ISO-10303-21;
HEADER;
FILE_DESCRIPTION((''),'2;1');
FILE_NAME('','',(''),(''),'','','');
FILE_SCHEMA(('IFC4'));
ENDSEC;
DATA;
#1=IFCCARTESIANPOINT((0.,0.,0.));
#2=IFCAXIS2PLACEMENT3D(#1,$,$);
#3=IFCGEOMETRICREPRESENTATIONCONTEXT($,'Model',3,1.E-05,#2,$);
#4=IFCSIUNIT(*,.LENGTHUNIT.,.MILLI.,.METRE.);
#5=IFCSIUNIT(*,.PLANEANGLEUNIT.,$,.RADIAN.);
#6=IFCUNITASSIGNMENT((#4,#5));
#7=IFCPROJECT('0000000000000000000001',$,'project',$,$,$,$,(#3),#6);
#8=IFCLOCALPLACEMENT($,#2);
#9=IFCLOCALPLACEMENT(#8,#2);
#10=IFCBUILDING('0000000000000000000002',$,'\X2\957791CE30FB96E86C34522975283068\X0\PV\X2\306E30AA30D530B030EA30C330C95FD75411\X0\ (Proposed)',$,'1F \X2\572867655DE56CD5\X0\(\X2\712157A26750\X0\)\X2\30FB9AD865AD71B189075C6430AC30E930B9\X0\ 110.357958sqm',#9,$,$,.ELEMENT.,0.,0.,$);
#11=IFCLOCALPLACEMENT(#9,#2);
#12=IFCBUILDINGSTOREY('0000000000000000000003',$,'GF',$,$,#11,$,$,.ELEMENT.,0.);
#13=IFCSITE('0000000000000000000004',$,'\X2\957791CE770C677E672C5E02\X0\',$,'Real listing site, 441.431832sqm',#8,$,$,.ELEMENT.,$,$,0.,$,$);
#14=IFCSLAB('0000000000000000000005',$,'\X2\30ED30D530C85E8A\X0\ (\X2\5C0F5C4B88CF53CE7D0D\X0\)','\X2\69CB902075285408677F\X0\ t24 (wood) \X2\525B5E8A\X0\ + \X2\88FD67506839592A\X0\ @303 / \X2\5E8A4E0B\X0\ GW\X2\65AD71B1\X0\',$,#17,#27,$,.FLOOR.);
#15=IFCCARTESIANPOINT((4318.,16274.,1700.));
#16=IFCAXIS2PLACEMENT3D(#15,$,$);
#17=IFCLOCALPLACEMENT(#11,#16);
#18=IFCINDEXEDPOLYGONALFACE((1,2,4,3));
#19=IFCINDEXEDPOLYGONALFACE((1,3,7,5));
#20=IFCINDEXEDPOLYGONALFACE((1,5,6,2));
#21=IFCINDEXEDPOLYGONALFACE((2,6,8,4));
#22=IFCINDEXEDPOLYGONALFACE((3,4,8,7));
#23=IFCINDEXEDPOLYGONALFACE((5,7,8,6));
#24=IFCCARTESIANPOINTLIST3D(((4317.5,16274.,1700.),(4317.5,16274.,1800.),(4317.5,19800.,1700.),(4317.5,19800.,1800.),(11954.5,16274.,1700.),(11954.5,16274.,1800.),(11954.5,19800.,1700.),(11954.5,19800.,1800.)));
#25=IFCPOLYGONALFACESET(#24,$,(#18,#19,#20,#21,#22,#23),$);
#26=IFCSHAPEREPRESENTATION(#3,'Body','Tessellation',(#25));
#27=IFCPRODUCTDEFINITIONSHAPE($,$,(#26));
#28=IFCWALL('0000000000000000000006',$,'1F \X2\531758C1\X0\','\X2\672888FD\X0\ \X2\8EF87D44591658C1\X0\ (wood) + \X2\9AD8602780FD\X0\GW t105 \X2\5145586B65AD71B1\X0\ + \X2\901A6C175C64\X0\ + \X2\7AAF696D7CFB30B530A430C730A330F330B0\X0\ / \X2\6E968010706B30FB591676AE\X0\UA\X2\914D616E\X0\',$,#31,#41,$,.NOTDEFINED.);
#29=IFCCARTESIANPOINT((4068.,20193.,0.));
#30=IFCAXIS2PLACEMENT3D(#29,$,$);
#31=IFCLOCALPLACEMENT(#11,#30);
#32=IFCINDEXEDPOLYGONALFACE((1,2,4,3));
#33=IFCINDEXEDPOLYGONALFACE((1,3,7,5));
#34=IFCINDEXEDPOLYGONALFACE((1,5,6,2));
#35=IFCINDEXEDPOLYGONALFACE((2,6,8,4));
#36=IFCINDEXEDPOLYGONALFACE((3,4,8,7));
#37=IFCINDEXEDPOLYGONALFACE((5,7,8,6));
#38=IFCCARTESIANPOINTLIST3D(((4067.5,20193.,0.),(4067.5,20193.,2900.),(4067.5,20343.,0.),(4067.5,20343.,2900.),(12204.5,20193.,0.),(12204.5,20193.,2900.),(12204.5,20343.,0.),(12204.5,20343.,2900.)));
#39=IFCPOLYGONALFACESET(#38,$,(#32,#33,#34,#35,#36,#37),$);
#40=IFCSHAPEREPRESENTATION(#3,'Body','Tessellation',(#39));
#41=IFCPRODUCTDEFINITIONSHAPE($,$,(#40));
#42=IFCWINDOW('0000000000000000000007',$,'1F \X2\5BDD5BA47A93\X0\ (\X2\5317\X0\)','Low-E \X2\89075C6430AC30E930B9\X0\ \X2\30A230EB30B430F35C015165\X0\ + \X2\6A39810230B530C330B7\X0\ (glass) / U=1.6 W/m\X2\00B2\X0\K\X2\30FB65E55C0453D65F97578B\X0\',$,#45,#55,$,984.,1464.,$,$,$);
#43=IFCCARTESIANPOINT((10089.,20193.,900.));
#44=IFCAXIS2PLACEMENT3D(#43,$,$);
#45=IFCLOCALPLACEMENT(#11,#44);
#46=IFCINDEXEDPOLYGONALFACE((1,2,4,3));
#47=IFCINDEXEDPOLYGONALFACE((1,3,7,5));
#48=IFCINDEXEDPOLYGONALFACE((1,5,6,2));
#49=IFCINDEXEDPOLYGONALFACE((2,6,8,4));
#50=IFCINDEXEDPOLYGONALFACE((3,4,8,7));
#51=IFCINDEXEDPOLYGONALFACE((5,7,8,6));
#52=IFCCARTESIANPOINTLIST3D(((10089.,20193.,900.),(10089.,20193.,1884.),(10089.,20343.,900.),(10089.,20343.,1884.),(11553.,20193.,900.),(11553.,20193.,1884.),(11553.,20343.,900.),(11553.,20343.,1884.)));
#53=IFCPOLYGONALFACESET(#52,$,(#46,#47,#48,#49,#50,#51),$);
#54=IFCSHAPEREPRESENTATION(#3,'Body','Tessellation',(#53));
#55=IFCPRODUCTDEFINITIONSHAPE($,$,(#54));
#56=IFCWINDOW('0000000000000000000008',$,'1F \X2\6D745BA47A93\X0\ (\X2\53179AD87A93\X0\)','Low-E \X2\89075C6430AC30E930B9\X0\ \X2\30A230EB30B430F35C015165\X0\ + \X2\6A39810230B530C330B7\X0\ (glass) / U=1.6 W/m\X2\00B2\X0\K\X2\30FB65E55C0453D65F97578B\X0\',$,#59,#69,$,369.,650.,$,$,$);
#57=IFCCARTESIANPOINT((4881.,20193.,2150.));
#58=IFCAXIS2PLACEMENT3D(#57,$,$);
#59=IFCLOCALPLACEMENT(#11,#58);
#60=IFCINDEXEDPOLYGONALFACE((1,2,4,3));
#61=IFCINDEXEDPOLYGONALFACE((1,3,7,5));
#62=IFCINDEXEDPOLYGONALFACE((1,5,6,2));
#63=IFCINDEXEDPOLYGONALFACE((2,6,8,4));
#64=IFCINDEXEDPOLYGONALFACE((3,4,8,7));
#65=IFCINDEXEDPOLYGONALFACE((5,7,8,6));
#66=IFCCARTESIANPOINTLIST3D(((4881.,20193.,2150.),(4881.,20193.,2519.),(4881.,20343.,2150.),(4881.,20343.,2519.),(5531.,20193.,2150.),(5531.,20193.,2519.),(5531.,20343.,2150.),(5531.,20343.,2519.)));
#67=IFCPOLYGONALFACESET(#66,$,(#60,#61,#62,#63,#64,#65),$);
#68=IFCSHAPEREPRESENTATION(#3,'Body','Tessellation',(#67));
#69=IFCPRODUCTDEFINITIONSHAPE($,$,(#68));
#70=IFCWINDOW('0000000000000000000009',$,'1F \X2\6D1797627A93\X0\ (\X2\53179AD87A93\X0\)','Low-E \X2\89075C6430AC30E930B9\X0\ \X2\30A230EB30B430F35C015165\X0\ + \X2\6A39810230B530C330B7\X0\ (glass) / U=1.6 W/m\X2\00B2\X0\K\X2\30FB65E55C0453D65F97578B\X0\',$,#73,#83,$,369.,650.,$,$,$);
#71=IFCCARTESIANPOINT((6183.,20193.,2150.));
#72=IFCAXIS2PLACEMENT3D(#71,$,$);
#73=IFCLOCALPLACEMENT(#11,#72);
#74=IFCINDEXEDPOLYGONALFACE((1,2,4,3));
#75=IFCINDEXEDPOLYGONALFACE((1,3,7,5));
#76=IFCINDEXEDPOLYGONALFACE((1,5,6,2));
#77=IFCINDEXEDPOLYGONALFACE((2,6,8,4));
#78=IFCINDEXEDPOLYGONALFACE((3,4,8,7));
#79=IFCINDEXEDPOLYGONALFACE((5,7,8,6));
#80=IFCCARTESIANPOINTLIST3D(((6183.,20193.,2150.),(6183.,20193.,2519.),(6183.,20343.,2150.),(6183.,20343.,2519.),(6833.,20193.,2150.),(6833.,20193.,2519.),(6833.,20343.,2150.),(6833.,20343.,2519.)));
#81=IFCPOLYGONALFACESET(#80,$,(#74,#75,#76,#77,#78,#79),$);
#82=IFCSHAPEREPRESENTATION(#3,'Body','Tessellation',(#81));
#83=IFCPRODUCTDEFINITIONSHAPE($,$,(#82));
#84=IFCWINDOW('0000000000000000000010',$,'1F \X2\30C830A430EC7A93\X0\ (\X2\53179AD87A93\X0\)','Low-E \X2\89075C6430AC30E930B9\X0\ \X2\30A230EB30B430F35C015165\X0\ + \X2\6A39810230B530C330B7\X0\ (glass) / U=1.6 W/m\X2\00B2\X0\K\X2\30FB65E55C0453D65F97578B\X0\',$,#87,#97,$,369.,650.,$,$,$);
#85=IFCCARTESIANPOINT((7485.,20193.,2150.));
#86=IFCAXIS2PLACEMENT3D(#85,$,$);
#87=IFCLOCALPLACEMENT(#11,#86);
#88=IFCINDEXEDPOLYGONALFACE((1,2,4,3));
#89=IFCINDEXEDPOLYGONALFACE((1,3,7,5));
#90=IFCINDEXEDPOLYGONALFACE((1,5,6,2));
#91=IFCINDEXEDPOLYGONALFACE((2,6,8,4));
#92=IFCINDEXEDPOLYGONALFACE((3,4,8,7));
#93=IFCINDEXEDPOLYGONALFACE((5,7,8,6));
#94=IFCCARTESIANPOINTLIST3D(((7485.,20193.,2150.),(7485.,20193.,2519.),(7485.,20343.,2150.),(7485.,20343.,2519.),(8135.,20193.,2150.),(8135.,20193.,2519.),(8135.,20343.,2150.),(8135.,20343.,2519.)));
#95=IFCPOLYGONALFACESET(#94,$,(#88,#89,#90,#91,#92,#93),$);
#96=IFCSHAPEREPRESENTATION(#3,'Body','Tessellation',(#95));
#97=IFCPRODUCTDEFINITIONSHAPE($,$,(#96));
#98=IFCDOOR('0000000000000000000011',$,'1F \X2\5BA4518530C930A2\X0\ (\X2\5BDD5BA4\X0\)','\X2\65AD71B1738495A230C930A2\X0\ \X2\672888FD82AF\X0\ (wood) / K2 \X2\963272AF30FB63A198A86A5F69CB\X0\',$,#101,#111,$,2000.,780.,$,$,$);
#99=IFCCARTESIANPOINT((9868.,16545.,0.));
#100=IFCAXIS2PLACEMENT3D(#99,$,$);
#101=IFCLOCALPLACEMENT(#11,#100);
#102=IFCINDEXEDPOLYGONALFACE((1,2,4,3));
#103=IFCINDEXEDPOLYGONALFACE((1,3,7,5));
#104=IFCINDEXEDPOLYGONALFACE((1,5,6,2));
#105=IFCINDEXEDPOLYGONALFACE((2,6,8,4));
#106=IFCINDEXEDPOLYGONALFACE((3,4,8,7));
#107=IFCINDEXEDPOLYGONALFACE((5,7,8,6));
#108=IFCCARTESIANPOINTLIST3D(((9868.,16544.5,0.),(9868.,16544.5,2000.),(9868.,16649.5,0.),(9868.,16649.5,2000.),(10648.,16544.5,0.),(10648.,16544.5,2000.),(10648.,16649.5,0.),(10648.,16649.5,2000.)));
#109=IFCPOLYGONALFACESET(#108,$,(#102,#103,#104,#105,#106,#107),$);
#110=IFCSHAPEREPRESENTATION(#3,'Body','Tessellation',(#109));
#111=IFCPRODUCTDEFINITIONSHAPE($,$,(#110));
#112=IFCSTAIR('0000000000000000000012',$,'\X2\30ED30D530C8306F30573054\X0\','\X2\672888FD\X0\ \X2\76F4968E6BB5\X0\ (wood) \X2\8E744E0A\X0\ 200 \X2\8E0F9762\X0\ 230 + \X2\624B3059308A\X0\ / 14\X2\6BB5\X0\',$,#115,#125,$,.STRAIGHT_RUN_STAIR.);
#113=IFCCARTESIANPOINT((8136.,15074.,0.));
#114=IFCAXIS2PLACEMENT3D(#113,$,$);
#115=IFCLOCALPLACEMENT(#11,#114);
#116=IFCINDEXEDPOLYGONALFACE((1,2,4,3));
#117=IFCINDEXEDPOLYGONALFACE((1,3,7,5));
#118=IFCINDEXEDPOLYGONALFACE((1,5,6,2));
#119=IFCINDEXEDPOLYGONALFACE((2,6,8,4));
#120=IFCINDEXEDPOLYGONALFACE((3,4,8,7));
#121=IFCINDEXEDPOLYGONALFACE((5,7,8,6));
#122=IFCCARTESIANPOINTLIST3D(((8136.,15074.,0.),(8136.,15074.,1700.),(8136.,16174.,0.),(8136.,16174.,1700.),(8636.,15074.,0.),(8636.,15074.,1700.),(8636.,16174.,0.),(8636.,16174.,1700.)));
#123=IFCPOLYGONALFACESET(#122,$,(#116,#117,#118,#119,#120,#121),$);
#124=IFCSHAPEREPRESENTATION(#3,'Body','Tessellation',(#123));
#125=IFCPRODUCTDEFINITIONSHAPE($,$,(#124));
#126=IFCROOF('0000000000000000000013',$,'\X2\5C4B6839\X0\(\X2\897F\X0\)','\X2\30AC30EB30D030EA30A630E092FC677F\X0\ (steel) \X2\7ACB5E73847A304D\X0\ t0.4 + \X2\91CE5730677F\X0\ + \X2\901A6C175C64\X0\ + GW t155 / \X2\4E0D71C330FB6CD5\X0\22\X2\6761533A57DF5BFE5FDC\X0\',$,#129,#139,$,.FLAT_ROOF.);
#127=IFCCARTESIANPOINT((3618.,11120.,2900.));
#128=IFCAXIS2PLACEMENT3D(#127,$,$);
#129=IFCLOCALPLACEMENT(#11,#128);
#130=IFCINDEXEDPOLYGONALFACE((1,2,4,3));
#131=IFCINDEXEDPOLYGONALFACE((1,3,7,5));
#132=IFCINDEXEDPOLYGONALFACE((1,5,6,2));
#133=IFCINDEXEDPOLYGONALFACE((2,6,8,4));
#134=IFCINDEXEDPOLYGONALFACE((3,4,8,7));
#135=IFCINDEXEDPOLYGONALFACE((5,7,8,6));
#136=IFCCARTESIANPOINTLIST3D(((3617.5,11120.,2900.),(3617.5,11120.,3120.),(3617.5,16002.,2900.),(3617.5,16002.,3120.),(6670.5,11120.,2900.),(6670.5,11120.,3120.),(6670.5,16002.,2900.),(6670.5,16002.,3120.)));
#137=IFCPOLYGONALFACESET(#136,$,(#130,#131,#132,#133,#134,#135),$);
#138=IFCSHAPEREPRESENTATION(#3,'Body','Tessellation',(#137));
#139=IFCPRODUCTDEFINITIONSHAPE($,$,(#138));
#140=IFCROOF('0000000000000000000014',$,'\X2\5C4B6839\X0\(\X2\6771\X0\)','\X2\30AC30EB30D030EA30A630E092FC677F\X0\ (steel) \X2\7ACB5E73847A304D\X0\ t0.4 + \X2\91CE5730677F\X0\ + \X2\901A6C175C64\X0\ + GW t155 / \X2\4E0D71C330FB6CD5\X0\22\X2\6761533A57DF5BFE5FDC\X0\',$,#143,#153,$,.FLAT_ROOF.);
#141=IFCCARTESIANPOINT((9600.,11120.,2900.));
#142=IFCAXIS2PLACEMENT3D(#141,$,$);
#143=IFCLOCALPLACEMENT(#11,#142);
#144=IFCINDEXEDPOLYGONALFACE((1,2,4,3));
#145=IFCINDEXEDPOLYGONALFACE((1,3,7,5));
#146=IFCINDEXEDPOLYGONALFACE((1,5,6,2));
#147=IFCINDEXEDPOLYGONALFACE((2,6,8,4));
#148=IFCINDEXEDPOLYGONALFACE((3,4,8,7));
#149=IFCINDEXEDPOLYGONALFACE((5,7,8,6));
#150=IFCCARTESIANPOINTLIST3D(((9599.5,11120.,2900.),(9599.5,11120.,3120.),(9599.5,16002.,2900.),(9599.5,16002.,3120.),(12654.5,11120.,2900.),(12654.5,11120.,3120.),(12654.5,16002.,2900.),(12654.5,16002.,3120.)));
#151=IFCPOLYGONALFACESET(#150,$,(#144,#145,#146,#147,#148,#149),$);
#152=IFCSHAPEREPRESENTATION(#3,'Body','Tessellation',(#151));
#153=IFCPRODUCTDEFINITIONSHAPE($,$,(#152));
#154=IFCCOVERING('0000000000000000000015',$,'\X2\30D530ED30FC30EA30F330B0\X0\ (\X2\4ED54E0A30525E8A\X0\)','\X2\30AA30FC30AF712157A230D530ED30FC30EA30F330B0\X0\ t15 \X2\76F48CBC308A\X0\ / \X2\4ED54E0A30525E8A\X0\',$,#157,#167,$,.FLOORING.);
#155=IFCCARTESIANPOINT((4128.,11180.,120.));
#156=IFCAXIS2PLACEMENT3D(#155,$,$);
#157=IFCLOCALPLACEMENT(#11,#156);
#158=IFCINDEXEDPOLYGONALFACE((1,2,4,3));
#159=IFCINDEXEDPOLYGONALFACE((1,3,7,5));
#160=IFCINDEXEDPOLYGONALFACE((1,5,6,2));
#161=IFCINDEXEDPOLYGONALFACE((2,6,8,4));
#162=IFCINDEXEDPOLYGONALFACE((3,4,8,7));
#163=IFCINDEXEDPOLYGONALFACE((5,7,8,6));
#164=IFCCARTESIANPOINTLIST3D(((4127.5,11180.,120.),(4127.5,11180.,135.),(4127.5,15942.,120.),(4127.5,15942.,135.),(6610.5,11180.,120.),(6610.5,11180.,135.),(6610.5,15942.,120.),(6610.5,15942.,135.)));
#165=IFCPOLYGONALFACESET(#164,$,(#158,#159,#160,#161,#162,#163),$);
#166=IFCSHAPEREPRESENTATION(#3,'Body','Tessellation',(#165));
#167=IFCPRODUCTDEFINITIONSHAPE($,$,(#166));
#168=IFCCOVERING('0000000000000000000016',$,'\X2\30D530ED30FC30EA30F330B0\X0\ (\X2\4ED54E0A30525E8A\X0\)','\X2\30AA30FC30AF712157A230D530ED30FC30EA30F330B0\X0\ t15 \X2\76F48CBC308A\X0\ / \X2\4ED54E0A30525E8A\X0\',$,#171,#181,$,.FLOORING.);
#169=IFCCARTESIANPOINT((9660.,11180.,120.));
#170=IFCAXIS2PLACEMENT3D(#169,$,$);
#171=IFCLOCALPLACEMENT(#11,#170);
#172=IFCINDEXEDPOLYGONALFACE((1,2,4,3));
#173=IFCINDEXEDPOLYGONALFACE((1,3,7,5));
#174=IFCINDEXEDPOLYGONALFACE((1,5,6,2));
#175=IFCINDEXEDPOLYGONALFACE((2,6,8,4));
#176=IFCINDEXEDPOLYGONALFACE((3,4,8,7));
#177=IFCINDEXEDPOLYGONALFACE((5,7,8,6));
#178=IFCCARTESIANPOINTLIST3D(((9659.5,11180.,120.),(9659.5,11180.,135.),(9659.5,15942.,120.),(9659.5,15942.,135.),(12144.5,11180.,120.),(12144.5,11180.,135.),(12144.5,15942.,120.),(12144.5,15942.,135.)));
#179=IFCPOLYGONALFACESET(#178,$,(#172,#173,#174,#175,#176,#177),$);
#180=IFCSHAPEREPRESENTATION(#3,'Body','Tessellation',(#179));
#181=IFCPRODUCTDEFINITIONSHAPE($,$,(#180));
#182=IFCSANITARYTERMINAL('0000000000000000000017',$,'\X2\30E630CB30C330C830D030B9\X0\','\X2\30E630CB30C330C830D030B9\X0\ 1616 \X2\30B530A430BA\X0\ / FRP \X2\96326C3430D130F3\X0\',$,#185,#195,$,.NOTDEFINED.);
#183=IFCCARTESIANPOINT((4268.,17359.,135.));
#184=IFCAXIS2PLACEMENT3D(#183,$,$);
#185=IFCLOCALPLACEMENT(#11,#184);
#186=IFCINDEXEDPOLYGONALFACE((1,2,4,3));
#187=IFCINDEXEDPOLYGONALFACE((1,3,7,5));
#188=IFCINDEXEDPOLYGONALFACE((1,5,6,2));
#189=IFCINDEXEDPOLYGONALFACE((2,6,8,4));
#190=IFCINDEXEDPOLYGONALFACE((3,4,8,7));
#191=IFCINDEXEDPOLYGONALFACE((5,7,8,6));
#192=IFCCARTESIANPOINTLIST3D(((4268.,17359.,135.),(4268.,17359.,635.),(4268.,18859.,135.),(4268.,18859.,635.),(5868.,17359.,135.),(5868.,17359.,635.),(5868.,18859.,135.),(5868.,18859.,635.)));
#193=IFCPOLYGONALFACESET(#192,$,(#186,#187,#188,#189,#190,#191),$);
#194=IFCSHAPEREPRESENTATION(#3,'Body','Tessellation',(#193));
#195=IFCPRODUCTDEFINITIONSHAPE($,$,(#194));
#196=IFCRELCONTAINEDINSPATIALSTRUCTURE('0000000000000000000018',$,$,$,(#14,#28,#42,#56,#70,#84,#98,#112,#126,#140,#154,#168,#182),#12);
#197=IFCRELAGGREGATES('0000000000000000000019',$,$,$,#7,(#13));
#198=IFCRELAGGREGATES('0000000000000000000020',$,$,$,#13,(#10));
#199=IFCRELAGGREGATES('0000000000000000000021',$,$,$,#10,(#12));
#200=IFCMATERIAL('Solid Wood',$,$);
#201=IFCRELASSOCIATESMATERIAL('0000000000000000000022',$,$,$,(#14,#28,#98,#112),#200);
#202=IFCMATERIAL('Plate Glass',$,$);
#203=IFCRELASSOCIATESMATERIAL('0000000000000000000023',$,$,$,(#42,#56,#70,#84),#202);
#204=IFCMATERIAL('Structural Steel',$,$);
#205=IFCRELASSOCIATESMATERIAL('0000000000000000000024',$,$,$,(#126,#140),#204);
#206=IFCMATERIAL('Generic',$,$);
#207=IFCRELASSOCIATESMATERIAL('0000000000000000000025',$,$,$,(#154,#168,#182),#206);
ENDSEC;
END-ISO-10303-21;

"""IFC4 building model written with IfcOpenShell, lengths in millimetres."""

from ifc_helpers import new_model, si_unit, frame, frame_2d, origin, place, context, project, spatial, rectangle, extrude, material, element, fill, save


model = new_model("IFC4")

# Units and contexts
model_context = context("Model", 3, precision=1e-05, world=origin())
ifc_project = project(units=[si_unit("LENGTHUNIT", "METRE", prefix="MILLI"), si_unit("PLANEANGLEUNIT", "RADIAN")], contexts=[model_context])

# Site, building, storey
site_placement = place(None, origin())
site = spatial("IfcSite", under=ifc_project, at=site_placement, Name="長野県松本市", ObjectType="Real listing site, 441.431832sqm", CompositionType="ELEMENT", RefElevation=0.0)
building_placement = place(site_placement, origin())
building = spatial("IfcBuilding", under=site, at=building_placement, Name="長野・雨水利用とPVのオフグリッド志向 (Proposed)", ObjectType="1F 在来工法(無垢材)・高断熱複層ガラス 110.357958sqm", CompositionType="ELEMENT", ElevationOfRefHeight=0.0, ElevationOfTerrain=0.0)
storey_placement = place(building_placement, origin())
storey = spatial("IfcBuildingStorey", under=building, at=storey_placement, Name="GF", CompositionType="ELEMENT", Elevation=0.0)

# Slab
ifc_material_1 = material(Name="Solid Wood")
slab_1_placement = place(storey_placement, frame((4318.0, 16274.0, 1700.0)))
element("IfcSlab", 1, at=slab_1_placement, inside=storey, material=ifc_material_1, Name="ロフト床 (小屋裏収納)", Description="構造用合板 t24 (wood) 剛床 + 製材根太 @303 / 床下 GW断熱", PredefinedType="FLOOR", context=model_context, shape_type="SweptSolid", body=[
    extrude(rectangle(XDim=7637.0, YDim=3526.0, at=frame_2d((3818.0, 1763.0))), frame((4318.0, 16274.0, 1700.0)), (0.0, 0.0, 1.0), 100.0),
])

# Wall, openings, windows
wall_1_placement = place(storey_placement, frame((4068.0, 20193.0, 0.0)))
wall_1 = element("IfcWall", 2, at=wall_1_placement, inside=storey, material=ifc_material_1, Name="1F 北壁", Description="木製 軸組外壁 (wood) + 高性能GW t105 充填断熱 + 通気層 + 窯業系サイディング / 準耐火・外皮UA配慮", PredefinedType="NOTDEFINED", context=model_context, shape_type="SweptSolid", body=[
    extrude(rectangle(XDim=8137.0, YDim=150.0, at=frame_2d((4068.0, 75.0))), frame((4068.0, 20193.0, 0.0)), (0.0, 0.0, 1.0), 2900.0),
])
opening_1_placement = place(storey_placement, frame((10089.0, 20193.0, 900.0)))
opening_1 = element("IfcOpeningElement", 3, at=opening_1_placement, cuts=wall_1, PredefinedType="NOTDEFINED", context=model_context, shape_type="SweptSolid", body=[
    extrude(rectangle(XDim=1464.0, YDim=150.0, at=frame_2d((732.0, 75.0))), frame((10089.0, 20193.0, 900.0)), (0.0, 0.0, 1.0), 984.0),
])
opening_2_placement = place(storey_placement, frame((4881.0, 20193.0, 2150.0)))
opening_2 = element("IfcOpeningElement", 4, at=opening_2_placement, cuts=wall_1, PredefinedType="NOTDEFINED", context=model_context, shape_type="SweptSolid", body=[
    extrude(rectangle(XDim=650.0, YDim=150.0, at=frame_2d((325.0, 75.0))), frame((4881.0, 20193.0, 2150.0)), (0.0, 0.0, 1.0), 369.0),
])
opening_3_placement = place(storey_placement, frame((6183.0, 20193.0, 2150.0)))
opening_3 = element("IfcOpeningElement", 5, at=opening_3_placement, cuts=wall_1, PredefinedType="NOTDEFINED", context=model_context, shape_type="SweptSolid", body=[
    extrude(rectangle(XDim=650.0, YDim=150.0, at=frame_2d((325.0, 75.0))), frame((6183.0, 20193.0, 2150.0)), (0.0, 0.0, 1.0), 369.0),
])
opening_4_placement = place(storey_placement, frame((7485.0, 20193.0, 2150.0)))
opening_4 = element("IfcOpeningElement", 6, at=opening_4_placement, cuts=wall_1, PredefinedType="NOTDEFINED", context=model_context, shape_type="SweptSolid", body=[
    extrude(rectangle(XDim=650.0, YDim=150.0, at=frame_2d((325.0, 75.0))), frame((7485.0, 20193.0, 2150.0)), (0.0, 0.0, 1.0), 369.0),
])
ifc_material_2 = material(Name="Plate Glass")
window_1_placement = place(storey_placement, frame((10089.0, 20193.0, 900.0)))
window_1 = element("IfcWindow", 7, at=window_1_placement, inside=storey, material=ifc_material_2, Name="1F 寝室窓 (北)", Description="Low-E 複層ガラス アルゴン封入 + 樹脂サッシ (glass) / U=1.6 W/m²K・日射取得型", OverallHeight=984.0, OverallWidth=1464.0, context=model_context, shape_type="SweptSolid", body=[
    extrude(rectangle(XDim=1464.0, YDim=150.0, at=frame_2d((732.0, 75.0))), frame((10089.0, 20193.0, 900.0)), (0.0, 0.0, 1.0), 984.0),
])
fill(opening_1, window_1)
window_2_placement = place(storey_placement, frame((4881.0, 20193.0, 2150.0)))
window_2 = element("IfcWindow", 8, at=window_2_placement, inside=storey, material=ifc_material_2, Name="1F 浴室窓 (北高窓)", Description="Low-E 複層ガラス アルゴン封入 + 樹脂サッシ (glass) / U=1.6 W/m²K・日射取得型", OverallHeight=369.0, OverallWidth=650.0, context=model_context, shape_type="SweptSolid", body=[
    extrude(rectangle(XDim=650.0, YDim=150.0, at=frame_2d((325.0, 75.0))), frame((4881.0, 20193.0, 2150.0)), (0.0, 0.0, 1.0), 369.0),
])
fill(opening_2, window_2)
window_3_placement = place(storey_placement, frame((6183.0, 20193.0, 2150.0)))
window_3 = element("IfcWindow", 9, at=window_3_placement, inside=storey, material=ifc_material_2, Name="1F 洗面窓 (北高窓)", Description="Low-E 複層ガラス アルゴン封入 + 樹脂サッシ (glass) / U=1.6 W/m²K・日射取得型", OverallHeight=369.0, OverallWidth=650.0, context=model_context, shape_type="SweptSolid", body=[
    extrude(rectangle(XDim=650.0, YDim=150.0, at=frame_2d((325.0, 75.0))), frame((6183.0, 20193.0, 2150.0)), (0.0, 0.0, 1.0), 369.0),
])
fill(opening_3, window_3)
window_4_placement = place(storey_placement, frame((7485.0, 20193.0, 2150.0)))
window_4 = element("IfcWindow", 10, at=window_4_placement, inside=storey, material=ifc_material_2, Name="1F トイレ窓 (北高窓)", Description="Low-E 複層ガラス アルゴン封入 + 樹脂サッシ (glass) / U=1.6 W/m²K・日射取得型", OverallHeight=369.0, OverallWidth=650.0, context=model_context, shape_type="SweptSolid", body=[
    extrude(rectangle(XDim=650.0, YDim=150.0, at=frame_2d((325.0, 75.0))), frame((7485.0, 20193.0, 2150.0)), (0.0, 0.0, 1.0), 369.0),
])
fill(opening_4, window_4)

# Door
door_1_placement = place(storey_placement, frame((9868.0, 16545.0, 0.0)))
element("IfcDoor", 11, at=door_1_placement, inside=storey, material=ifc_material_1, Name="1F 室内ドア (寝室)", Description="断熱玄関ドア 木製芯 (wood) / K2 防犯・採風機構", OverallHeight=2000.0, OverallWidth=780.0, context=model_context, shape_type="SweptSolid", body=[
    extrude(rectangle(XDim=780.0, YDim=105.0, at=frame_2d((390.0, 52.0))), frame((9868.0, 16545.0, 0.0)), (0.0, 0.0, 1.0), 2000.0),
])

# Stair
stair_placement = place(storey_placement, frame((8136.0, 15074.0, 0.0)))
element("IfcStair", 12, at=stair_placement, inside=storey, material=ifc_material_1, Name="ロフトはしご", Description="木製 直階段 (wood) 蹴上 200 踏面 230 + 手すり / 14段", PredefinedType="STRAIGHT_RUN_STAIR", context=model_context, shape_type="SweptSolid", body=[
    extrude(rectangle(XDim=500.0, YDim=1100.0, at=frame_2d((250.0, 550.0))), frame((8136.0, 15074.0, 0.0)), (0.0, 0.0, 1.0), 1700.0),
])

# Roofs
ifc_material_3 = material(Name="Structural Steel")
roof_1_placement = place(storey_placement, frame((3618.0, 11120.0, 2900.0)))
element("IfcRoof", 13, at=roof_1_placement, inside=storey, material=ifc_material_3, Name="屋根(西)", Description="ガルバリウム鋼板 (steel) 立平葺き t0.4 + 野地板 + 通気層 + GW t155 / 不燃・法22条区域対応", PredefinedType="FLAT_ROOF", context=model_context, shape_type="SweptSolid", body=[
    extrude(rectangle(XDim=3053.0, YDim=4882.0, at=frame_2d((1526.0, 2441.0))), frame((3618.0, 11120.0, 2900.0)), (0.0, 0.0, 1.0), 220.0),
])
roof_2_placement = place(storey_placement, frame((9600.0, 11120.0, 2900.0)))
element("IfcRoof", 14, at=roof_2_placement, inside=storey, material=ifc_material_3, Name="屋根(東)", Description="ガルバリウム鋼板 (steel) 立平葺き t0.4 + 野地板 + 通気層 + GW t155 / 不燃・法22条区域対応", PredefinedType="FLAT_ROOF", context=model_context, shape_type="SweptSolid", body=[
    extrude(rectangle(XDim=3055.0, YDim=4882.0, at=frame_2d((1527.0, 2441.0))), frame((9600.0, 11120.0, 2900.0)), (0.0, 0.0, 1.0), 220.0),
])

# Coverings
ifc_material_4 = material(Name="Generic")
covering_1_placement = place(storey_placement, frame((4128.0, 11180.0, 120.0)))
element("IfcCovering", 15, at=covering_1_placement, inside=storey, material=ifc_material_4, Name="フローリング (仕上げ床)", Description="オーク無垢フローリング t15 直貼り / 仕上げ床", PredefinedType="FLOORING", context=model_context, shape_type="SweptSolid", body=[
    extrude(rectangle(XDim=2483.0, YDim=4762.0, at=frame_2d((1241.0, 2381.0))), frame((4128.0, 11180.0, 120.0)), (0.0, 0.0, 1.0), 15.0),
])
covering_2_placement = place(storey_placement, frame((9660.0, 11180.0, 120.0)))
element("IfcCovering", 16, at=covering_2_placement, inside=storey, material=ifc_material_4, Name="フローリング (仕上げ床)", Description="オーク無垢フローリング t15 直貼り / 仕上げ床", PredefinedType="FLOORING", context=model_context, shape_type="SweptSolid", body=[
    extrude(rectangle(XDim=2485.0, YDim=4762.0, at=frame_2d((1242.0, 2381.0))), frame((9660.0, 11180.0, 120.0)), (0.0, 0.0, 1.0), 15.0),
])

# Sanitary terminal
sanitary_terminal_1_placement = place(storey_placement, frame((4268.0, 17359.0, 135.0)))
element("IfcSanitaryTerminal", 17, at=sanitary_terminal_1_placement, inside=storey, material=ifc_material_4, Name="ユニットバス", Description="ユニットバス 1616 サイズ / FRP 防水パン", PredefinedType="NOTDEFINED", context=model_context, shape_type="SweptSolid", body=[
    extrude(rectangle(XDim=1600.0, YDim=1500.0, at=frame_2d((800.0, 750.0))), frame((4268.0, 17359.0, 135.0)), (0.0, 0.0, 1.0), 500.0),
])

save(model, "model.ifc")
